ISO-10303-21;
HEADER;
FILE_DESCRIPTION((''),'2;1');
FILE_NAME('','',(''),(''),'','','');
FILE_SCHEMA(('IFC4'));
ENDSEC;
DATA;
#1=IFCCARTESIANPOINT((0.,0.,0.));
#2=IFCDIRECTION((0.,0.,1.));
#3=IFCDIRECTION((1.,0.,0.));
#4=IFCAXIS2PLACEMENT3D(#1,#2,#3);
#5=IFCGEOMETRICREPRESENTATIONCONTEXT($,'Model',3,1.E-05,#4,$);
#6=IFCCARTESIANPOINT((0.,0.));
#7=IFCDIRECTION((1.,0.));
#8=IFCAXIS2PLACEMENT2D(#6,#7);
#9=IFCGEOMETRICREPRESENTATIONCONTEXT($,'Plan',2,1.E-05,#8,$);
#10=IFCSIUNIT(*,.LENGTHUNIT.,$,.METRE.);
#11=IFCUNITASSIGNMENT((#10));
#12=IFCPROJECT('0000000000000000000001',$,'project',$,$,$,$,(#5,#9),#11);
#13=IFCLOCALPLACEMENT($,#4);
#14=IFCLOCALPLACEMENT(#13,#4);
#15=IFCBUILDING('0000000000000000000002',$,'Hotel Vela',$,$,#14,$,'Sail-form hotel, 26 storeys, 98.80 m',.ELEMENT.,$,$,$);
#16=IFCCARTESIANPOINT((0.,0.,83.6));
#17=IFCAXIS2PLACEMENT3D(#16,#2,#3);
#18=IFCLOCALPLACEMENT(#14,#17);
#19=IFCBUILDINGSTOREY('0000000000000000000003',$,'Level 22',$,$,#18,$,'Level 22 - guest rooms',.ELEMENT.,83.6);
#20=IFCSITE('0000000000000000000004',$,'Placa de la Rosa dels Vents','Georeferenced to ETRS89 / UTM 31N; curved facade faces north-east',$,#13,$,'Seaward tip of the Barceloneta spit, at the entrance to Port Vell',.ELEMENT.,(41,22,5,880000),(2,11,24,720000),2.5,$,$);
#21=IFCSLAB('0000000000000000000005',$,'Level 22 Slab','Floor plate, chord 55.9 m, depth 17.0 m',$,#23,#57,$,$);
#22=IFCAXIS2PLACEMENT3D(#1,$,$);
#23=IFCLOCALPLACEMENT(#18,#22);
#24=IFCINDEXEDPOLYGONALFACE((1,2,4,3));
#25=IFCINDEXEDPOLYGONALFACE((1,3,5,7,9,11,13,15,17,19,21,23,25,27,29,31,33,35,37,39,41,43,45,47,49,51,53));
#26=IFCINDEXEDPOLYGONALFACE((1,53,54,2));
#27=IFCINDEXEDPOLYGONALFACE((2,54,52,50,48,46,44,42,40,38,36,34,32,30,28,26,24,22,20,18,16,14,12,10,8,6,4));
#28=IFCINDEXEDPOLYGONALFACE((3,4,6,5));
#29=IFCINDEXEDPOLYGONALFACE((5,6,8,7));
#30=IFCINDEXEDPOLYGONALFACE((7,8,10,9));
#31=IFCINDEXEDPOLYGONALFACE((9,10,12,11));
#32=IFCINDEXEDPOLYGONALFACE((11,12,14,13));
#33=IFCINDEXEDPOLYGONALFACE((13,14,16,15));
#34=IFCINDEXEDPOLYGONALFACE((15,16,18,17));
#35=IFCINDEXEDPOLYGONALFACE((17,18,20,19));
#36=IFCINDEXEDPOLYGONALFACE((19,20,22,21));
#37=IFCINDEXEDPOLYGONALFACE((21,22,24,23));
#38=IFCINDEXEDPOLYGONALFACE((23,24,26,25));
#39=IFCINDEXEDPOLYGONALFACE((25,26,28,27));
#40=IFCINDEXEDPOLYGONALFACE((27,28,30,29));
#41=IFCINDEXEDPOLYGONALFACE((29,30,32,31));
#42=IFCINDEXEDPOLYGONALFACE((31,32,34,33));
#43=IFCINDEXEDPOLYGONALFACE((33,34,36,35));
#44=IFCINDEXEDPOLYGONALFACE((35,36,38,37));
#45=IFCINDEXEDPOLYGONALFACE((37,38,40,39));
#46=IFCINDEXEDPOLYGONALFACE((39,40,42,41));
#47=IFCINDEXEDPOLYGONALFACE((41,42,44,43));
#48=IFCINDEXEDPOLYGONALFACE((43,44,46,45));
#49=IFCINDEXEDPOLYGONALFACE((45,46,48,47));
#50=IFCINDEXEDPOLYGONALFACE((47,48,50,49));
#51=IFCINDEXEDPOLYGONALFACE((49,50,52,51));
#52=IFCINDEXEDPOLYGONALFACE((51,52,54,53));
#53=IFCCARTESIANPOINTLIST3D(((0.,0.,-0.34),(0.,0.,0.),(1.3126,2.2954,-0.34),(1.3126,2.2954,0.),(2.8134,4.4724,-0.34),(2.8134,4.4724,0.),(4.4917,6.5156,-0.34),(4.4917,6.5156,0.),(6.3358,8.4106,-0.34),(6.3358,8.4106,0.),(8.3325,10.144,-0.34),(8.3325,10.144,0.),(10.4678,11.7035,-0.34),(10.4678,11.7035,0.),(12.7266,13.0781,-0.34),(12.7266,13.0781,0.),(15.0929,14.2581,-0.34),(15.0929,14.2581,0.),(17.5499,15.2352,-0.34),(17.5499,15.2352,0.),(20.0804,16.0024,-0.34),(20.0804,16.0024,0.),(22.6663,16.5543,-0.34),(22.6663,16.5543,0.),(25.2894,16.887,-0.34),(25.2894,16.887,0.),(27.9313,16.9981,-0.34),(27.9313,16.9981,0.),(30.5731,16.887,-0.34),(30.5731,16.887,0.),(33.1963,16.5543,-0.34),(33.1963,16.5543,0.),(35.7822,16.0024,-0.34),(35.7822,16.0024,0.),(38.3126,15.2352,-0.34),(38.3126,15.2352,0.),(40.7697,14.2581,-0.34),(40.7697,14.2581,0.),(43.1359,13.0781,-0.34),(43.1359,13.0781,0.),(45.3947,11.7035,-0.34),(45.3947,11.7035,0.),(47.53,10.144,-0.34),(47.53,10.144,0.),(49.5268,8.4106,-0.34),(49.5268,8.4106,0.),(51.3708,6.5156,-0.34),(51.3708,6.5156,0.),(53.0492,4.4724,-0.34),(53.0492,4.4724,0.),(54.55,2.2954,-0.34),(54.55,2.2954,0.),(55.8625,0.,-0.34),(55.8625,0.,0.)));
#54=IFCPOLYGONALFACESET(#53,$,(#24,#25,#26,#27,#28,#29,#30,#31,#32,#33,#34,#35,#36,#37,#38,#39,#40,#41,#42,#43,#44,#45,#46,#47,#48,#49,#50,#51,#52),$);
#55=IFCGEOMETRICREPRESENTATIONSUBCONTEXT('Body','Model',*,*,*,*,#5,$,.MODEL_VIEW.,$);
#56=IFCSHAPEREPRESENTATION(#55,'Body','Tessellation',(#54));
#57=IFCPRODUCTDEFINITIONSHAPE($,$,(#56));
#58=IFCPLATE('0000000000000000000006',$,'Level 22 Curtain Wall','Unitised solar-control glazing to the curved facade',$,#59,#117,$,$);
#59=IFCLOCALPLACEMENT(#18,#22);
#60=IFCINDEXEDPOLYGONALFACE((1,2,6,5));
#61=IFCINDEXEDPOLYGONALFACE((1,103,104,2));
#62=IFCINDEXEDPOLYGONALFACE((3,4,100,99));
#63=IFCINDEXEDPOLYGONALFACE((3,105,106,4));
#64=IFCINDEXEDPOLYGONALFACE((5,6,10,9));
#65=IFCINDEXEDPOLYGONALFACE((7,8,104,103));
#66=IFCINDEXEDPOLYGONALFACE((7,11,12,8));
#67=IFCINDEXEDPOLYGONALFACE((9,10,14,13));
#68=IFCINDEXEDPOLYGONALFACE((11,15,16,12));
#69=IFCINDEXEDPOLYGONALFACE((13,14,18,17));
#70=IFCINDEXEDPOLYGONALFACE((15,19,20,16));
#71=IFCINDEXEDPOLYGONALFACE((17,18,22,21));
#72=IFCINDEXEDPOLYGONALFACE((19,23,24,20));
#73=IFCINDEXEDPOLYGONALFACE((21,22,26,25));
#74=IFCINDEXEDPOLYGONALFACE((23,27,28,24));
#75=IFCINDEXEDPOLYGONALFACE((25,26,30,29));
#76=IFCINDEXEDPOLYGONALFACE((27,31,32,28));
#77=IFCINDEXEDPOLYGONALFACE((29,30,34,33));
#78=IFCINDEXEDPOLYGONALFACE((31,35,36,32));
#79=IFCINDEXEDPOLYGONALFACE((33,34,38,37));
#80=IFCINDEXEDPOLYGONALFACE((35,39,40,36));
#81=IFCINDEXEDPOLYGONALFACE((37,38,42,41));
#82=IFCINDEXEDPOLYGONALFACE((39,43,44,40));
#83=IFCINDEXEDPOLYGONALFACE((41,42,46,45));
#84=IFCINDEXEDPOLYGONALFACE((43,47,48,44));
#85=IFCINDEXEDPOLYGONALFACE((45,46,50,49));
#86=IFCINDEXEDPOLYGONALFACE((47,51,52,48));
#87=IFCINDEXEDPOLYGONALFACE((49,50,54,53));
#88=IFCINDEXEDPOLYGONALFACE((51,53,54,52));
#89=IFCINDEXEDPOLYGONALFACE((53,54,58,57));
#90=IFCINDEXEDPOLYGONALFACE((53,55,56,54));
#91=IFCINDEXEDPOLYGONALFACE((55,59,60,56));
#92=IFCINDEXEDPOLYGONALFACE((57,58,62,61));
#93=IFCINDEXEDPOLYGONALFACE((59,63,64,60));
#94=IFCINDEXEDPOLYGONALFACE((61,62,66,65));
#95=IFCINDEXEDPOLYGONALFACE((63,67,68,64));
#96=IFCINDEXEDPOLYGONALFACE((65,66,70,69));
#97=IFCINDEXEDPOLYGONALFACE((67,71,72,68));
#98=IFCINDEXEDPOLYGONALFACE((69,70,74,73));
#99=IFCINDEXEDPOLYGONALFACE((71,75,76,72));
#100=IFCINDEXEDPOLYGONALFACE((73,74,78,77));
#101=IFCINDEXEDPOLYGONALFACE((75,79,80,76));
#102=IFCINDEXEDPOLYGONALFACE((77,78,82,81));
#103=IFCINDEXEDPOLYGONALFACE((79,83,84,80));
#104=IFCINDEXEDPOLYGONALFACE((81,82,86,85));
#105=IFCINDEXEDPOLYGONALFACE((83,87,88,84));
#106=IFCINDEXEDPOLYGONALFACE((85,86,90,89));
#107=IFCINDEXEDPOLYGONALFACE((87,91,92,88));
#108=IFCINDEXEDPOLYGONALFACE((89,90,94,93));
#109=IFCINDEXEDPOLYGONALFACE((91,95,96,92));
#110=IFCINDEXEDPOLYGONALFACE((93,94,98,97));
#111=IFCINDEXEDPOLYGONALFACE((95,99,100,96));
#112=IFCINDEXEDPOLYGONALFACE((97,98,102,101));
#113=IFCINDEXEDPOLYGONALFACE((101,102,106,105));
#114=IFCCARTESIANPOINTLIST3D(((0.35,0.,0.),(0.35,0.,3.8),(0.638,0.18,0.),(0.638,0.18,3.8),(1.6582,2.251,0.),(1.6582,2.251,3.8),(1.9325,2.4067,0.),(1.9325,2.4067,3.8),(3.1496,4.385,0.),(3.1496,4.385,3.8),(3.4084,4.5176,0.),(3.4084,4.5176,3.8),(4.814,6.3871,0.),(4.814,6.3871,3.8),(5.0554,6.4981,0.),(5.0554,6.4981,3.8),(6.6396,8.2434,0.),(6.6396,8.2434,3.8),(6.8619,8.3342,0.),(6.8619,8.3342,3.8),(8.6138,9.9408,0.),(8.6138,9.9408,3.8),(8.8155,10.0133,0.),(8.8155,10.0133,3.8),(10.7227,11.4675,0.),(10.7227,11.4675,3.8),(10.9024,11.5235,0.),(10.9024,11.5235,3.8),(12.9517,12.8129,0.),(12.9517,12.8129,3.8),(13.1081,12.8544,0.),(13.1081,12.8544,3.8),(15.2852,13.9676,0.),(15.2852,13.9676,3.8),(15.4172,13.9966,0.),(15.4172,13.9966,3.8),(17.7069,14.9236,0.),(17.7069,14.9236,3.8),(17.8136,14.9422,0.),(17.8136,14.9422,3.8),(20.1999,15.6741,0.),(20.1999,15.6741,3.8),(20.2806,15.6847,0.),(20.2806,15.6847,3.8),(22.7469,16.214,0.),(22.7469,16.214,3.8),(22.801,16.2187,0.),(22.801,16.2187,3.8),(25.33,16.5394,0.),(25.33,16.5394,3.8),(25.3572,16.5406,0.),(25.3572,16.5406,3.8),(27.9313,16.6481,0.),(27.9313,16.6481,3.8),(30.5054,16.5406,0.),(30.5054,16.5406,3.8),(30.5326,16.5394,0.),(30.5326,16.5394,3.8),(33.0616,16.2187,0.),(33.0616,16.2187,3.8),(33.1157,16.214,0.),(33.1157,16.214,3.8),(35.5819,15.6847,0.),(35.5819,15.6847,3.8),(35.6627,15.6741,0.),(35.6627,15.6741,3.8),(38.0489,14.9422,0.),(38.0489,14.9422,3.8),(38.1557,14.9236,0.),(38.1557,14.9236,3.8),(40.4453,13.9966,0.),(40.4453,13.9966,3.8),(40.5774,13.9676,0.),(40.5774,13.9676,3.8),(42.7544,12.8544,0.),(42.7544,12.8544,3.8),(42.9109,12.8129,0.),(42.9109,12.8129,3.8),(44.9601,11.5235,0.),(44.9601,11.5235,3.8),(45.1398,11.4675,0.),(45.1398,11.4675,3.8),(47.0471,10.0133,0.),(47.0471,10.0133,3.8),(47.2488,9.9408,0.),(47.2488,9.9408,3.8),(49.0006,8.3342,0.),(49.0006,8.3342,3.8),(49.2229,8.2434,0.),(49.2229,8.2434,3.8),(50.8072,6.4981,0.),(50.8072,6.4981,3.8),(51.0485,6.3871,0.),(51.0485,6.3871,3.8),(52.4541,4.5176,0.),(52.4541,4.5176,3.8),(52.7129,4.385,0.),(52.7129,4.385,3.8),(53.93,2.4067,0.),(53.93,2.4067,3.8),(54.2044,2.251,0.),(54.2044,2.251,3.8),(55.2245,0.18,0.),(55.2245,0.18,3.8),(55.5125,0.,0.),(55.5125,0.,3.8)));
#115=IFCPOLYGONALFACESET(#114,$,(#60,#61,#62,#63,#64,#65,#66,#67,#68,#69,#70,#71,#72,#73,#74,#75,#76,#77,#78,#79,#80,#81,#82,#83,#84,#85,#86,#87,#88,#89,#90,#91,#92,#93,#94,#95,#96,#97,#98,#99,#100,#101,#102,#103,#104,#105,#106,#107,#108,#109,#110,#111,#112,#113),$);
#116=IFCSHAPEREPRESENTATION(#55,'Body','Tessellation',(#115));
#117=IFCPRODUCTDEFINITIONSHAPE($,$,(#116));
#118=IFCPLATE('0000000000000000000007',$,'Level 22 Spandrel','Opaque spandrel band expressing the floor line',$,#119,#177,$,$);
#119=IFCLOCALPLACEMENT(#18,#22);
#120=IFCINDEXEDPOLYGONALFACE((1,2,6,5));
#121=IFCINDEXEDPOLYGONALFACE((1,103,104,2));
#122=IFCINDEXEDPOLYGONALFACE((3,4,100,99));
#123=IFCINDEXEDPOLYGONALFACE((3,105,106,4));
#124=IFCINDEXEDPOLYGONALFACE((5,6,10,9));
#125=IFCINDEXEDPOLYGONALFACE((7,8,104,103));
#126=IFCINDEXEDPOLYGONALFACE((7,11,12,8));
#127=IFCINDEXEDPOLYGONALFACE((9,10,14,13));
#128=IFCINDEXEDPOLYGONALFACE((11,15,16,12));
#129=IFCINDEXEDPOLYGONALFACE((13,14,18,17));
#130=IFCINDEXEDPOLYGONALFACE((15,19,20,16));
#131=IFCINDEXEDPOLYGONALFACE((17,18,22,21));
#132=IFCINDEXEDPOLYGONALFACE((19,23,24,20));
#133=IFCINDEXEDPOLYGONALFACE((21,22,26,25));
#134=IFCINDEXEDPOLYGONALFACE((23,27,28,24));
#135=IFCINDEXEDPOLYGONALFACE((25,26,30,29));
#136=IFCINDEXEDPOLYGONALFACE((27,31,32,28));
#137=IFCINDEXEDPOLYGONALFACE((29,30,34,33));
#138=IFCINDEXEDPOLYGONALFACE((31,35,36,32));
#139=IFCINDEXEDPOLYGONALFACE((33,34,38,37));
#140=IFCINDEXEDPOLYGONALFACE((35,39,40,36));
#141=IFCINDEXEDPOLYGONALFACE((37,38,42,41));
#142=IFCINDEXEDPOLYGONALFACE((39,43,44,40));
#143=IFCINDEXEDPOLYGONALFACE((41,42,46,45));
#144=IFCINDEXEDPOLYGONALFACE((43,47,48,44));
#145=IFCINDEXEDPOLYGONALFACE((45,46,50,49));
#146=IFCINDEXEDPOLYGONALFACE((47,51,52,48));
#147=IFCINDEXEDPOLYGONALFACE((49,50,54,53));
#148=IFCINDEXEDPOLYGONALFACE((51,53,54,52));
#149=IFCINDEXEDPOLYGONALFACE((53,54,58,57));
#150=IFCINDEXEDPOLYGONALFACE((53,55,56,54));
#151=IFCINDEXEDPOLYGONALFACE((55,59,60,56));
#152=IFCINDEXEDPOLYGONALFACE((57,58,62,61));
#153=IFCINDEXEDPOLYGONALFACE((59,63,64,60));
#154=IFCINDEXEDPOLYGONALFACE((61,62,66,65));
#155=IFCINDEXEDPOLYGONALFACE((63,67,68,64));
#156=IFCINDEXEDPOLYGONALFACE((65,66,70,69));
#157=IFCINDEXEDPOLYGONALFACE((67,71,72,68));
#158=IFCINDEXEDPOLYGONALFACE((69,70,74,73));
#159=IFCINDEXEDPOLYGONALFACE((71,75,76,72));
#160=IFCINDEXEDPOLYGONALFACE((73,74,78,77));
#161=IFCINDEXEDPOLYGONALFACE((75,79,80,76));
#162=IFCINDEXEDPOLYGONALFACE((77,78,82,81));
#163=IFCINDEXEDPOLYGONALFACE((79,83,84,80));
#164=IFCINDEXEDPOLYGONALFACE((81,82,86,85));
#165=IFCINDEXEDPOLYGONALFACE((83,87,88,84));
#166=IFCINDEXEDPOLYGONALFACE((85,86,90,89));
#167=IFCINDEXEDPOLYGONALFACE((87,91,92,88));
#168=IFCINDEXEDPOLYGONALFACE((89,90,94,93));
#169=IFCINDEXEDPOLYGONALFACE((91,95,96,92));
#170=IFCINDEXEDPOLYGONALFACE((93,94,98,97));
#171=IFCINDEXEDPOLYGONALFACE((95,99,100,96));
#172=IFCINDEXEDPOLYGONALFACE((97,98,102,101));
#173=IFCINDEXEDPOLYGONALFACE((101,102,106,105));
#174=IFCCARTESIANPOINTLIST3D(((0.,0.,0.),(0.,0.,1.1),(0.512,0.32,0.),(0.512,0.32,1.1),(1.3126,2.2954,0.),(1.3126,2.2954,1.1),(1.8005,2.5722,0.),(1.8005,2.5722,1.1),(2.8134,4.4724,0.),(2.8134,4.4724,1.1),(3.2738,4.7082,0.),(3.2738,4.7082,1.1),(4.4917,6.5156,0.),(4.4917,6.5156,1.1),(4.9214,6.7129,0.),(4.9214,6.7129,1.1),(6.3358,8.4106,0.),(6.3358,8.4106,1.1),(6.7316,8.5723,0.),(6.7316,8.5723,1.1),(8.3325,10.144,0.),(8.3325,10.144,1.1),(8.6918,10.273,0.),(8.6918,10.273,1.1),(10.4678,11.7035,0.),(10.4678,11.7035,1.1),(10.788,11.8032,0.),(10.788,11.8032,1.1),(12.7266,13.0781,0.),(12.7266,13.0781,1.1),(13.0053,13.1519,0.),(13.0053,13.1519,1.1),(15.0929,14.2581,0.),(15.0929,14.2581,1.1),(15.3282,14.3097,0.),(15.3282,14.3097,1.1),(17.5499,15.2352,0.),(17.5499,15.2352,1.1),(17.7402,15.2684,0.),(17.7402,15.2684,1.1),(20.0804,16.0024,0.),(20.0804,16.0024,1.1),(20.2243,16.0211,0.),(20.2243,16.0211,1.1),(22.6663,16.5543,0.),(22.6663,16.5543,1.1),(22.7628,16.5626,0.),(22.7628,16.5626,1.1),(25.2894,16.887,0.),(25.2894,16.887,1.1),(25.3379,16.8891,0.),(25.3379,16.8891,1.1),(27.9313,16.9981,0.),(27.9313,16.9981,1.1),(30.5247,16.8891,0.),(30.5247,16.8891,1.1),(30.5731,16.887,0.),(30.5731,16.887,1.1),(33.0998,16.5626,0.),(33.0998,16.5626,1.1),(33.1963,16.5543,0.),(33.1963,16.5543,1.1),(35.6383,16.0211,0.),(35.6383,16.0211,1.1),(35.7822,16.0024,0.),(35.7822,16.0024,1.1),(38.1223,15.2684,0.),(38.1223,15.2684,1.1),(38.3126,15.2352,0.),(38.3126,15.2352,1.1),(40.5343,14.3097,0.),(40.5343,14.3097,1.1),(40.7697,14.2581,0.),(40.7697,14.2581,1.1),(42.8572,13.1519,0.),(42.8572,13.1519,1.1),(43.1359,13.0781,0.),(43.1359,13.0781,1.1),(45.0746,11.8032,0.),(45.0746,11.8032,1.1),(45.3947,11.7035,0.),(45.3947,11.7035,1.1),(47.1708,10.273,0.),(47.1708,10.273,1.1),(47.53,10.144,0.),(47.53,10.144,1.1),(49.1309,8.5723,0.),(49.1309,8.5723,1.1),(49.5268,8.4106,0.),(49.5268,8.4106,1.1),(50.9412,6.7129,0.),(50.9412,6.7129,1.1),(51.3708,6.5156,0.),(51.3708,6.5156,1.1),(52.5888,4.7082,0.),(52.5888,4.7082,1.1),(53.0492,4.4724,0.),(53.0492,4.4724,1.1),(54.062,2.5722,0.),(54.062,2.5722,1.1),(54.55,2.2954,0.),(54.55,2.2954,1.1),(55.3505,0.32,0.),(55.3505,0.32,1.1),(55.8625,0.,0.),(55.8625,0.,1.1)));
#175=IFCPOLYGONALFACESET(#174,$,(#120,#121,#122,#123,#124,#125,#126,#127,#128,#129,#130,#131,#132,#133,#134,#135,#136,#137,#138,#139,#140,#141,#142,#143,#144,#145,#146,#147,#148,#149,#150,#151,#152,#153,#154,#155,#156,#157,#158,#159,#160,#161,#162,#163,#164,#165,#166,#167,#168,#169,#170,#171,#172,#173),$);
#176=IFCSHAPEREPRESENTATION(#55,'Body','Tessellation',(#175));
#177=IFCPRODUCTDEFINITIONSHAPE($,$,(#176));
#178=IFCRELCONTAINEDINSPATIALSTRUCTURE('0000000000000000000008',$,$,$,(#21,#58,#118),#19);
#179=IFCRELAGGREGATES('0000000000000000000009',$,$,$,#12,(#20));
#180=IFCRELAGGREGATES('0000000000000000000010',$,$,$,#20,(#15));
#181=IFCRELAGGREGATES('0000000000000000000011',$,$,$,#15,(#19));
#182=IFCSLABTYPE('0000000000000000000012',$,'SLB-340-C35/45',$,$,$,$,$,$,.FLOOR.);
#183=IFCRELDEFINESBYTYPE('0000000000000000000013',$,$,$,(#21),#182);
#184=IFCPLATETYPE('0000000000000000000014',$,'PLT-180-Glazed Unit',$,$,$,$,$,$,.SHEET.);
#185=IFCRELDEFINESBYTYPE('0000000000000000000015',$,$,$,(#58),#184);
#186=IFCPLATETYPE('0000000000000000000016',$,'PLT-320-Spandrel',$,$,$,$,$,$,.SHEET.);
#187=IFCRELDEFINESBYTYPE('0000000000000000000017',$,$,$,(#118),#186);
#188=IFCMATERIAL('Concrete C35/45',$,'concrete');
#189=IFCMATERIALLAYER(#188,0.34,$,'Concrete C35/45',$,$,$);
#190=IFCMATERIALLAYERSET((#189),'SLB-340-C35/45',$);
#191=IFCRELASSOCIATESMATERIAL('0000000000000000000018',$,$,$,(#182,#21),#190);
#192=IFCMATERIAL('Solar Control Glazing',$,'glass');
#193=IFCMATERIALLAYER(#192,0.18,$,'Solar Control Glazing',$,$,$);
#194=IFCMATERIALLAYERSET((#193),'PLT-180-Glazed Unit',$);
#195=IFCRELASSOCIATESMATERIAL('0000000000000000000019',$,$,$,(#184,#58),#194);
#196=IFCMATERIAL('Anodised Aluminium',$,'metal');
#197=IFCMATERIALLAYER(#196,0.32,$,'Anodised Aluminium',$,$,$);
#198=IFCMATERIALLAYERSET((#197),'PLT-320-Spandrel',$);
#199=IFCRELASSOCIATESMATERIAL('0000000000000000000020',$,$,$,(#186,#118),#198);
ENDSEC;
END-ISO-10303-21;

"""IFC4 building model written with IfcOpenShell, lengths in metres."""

from ifc_helpers import new_model, si_unit, frame, origin_with_axes, origin_2d_with_axis, place, context, subcontext, project, spatial, line, indexed_curve, outline, extrude, material, layer, layer_set, layer_usage, type_object, element, save


model = new_model("IFC4")

# Units and contexts
model_context = context("Model", 3, precision=1e-05, world=origin_with_axes())
plan_context = context("Plan", 2, precision=1e-05, world=origin_2d_with_axis())
body_context = subcontext(model_context, "Body", "Model", "MODEL_VIEW")
ifc_project = project(units=[si_unit("LENGTHUNIT", "METRE")], contexts=[model_context, plan_context])

# Site, building, storey
site_placement = place(None, origin_with_axes())
site = spatial("IfcSite", under=ifc_project, at=site_placement, Name="Placa de la Rosa dels Vents", Description="Georeferenced to ETRS89 / UTM 31N; curved facade faces north-east", LongName="Seaward tip of the Barceloneta spit, at the entrance to Port Vell", CompositionType="ELEMENT", RefLatitude=(41, 22, 5, 880000), RefLongitude=(2, 11, 24, 720000), RefElevation=2.5)
building_placement = place(site_placement, origin_with_axes())
building = spatial("IfcBuilding", under=site, at=building_placement, Name="Hotel Vela", LongName="Sail-form hotel, 26 storeys, 98.80 m", CompositionType="ELEMENT")
storey_placement = place(building_placement, frame((0.0, 0.0, 83.6), z_axis=(0.0, 0.0, 1.0), x_axis=(1.0, 0.0, 0.0)))
storey = spatial("IfcBuildingStorey", under=building, at=storey_placement, Name="Level 22", LongName="Level 22 - guest rooms", CompositionType="ELEMENT", Elevation=83.6)

# Slab
ifc_material_1 = material(Name="Concrete C35/45", Category="concrete")
ifc_layer_1 = layer(ifc_material_1, 0.34, Name="Concrete C35/45")
ifc_layer_set_1 = layer_set([ifc_layer_1], Name="SLB-340-C35/45")
ifc_layer_usage_1 = layer_usage(ifc_layer_set_1, "AXIS3", "POSITIVE", 0.0)
slab_type = type_object("IfcSlabType", Name="SLB-340-C35/45", PredefinedType="FLOOR", material=ifc_layer_set_1)
slab_placement = place(storey_placement, frame((0.0, 0.0, -0.34), z_axis=(0.0, 0.0, 1.0), x_axis=(1.0, 0.0, 0.0)))
element("IfcSlab", 1, at=slab_placement, inside=storey, type_object=slab_type, material=ifc_layer_usage_1, Name="Level 22 Slab", Description="Floor plate, chord 55.9 m, depth 17.0 m", context=body_context, shape_type="SweptSolid", body=[
    extrude(outline(indexed_curve([(0.0, 0.0), (55.8625, 0.0), (54.55, 2.2954), (53.0492, 4.4724), (51.3708, 6.5156), (49.5268, 8.4106), (47.53, 10.144), (45.3947, 11.7035), (43.1359, 13.0781), (40.7697, 14.2581), (38.3126, 15.2352), (35.7822, 16.0024), (33.1963, 16.5543), (30.5731, 16.887), (27.9313, 16.9981), (25.2894, 16.887), (22.6663, 16.5543), (20.0804, 16.0024), (17.5499, 15.2352), (15.0929, 14.2581), (12.7266, 13.0781), (10.4678, 11.7035), (8.3325, 10.144), (6.3358, 8.4106), (4.4917, 6.5156), (2.8134, 4.4724), (1.3126, 2.2954)], segments=[line(1, 2, 3, 4, 5, 6, 7, 8, 9, 10, 11, 12, 13, 14, 15, 16, 17, 18, 19, 20, 21, 22, 23, 24, 25, 26, 27, 1)])), origin_with_axes(), (0.0, 0.0, 1.0), 0.34),
])

# Plates
ifc_material_2 = material(Name="Solar Control Glazing", Category="glass")
ifc_layer_2 = layer(ifc_material_2, 0.18, Name="Solar Control Glazing")
ifc_layer_set_2 = layer_set([ifc_layer_2], Name="PLT-180-Glazed Unit")
ifc_layer_usage_2 = layer_usage(ifc_layer_set_2, "AXIS2", "POSITIVE", 0.0)
plate_type_1 = type_object("IfcPlateType", Name="PLT-180-Glazed Unit", PredefinedType="SHEET", material=ifc_layer_set_2)
plate_1_placement = place(storey_placement, frame((0.35, 0.0, 0.0), z_axis=(0.0, 0.0, 1.0), x_axis=(1.0, 0.0, 0.0)))
element("IfcPlate", 2, at=plate_1_placement, inside=storey, type_object=plate_type_1, material=ifc_layer_usage_2, Name="Level 22 Curtain Wall", Description="Unitised solar-control glazing to the curved facade", context=body_context, shape_type="SweptSolid", body=[
    extrude(outline(indexed_curve([(55.1625, 0.0), (53.8544, 2.251), (52.3629, 4.385), (50.6985, 6.3871), (48.8729, 8.2434), (46.8988, 9.9408), (44.7898, 11.4675), (42.5609, 12.8129), (40.2274, 13.9676), (37.8057, 14.9236), (35.3127, 15.6741), (32.7657, 16.214), (30.1826, 16.5394), (27.5813, 16.6481), (24.98, 16.5394), (22.3969, 16.214), (19.8499, 15.6741), (17.3569, 14.9236), (14.9352, 13.9676), (12.6017, 12.8129), (10.3727, 11.4675), (8.2638, 9.9408), (6.2896, 8.2434), (4.464, 6.3871), (2.7996, 4.385), (1.3082, 2.251), (0.0, 0.0), (54.8745, 0.18), (1.5825, 2.4067), (3.0584, 4.5176), (4.7054, 6.4981), (6.5119, 8.3342), (8.4655, 10.0133), (10.5524, 11.5235), (12.7581, 12.8544), (15.0672, 13.9966), (17.4636, 14.9422), (19.9306, 15.6847), (22.451, 16.2187), (25.0072, 16.5406), (27.5813, 16.6481), (30.1554, 16.5406), (32.7116, 16.2187), (35.2319, 15.6847), (37.6989, 14.9422), (40.0953, 13.9966), (42.4044, 12.8544), (44.6101, 11.5235), (46.6971, 10.0133), (48.6506, 8.3342), (50.4572, 6.4981), (52.1041, 4.5176), (53.58, 2.4067), (0.288, 0.18)], segments=[line(1, 2, 3, 4, 5, 6, 7, 8, 9, 10, 11, 12, 13, 14, 15, 16, 17, 18, 19, 20, 21, 22, 23, 24, 25, 26, 27, 28, 29, 30, 31, 32, 33, 34, 35, 36, 37, 38, 39, 40, 41, 42, 43, 44, 45, 46, 47, 48, 49, 50, 51, 52, 53, 54, 1)])), origin_with_axes(), (0.0, 0.0, 1.0), 3.8),
])
ifc_material_3 = material(Name="Anodised Aluminium", Category="metal")
ifc_layer_3 = layer(ifc_material_3, 0.32, Name="Anodised Aluminium")
ifc_layer_set_3 = layer_set([ifc_layer_3], Name="PLT-320-Spandrel")
ifc_layer_usage_3 = layer_usage(ifc_layer_set_3, "AXIS2", "POSITIVE", 0.0)
plate_type_2 = type_object("IfcPlateType", Name="PLT-320-Spandrel", PredefinedType="SHEET", material=ifc_layer_set_3)
plate_2_placement = place(storey_placement, origin_with_axes())
element("IfcPlate", 3, at=plate_2_placement, inside=storey, type_object=plate_type_2, material=ifc_layer_usage_3, Name="Level 22 Spandrel", Description="Opaque spandrel band expressing the floor line", context=body_context, shape_type="SweptSolid", body=[
    extrude(outline(indexed_curve([(55.8625, 0.0), (54.55, 2.2954), (53.0492, 4.4724), (51.3708, 6.5156), (49.5268, 8.4106), (47.53, 10.144), (45.3947, 11.7035), (43.1359, 13.0781), (40.7697, 14.2581), (38.3126, 15.2352), (35.7822, 16.0024), (33.1963, 16.5543), (30.5731, 16.887), (27.9313, 16.9981), (25.2894, 16.887), (22.6663, 16.5543), (20.0804, 16.0024), (17.5499, 15.2352), (15.0929, 14.2581), (12.7266, 13.0781), (10.4678, 11.7035), (8.3325, 10.144), (6.3358, 8.4106), (4.4917, 6.5156), (2.8134, 4.4724), (1.3126, 2.2954), (0.0, 0.0), (55.3505, 0.32), (1.8005, 2.5722), (3.2738, 4.7082), (4.9214, 6.7129), (6.7316, 8.5723), (8.6918, 10.273), (10.788, 11.8032), (13.0053, 13.1519), (15.3282, 14.3097), (17.7402, 15.2684), (20.2243, 16.0211), (22.7628, 16.5626), (25.3379, 16.8891), (27.9313, 16.9981), (30.5247, 16.8891), (33.0998, 16.5626), (35.6383, 16.0211), (38.1223, 15.2684), (40.5343, 14.3097), (42.8572, 13.1519), (45.0746, 11.8032), (47.1708, 10.273), (49.1309, 8.5723), (50.9412, 6.7129), (52.5888, 4.7082), (54.062, 2.5722), (0.512, 0.32)], segments=[line(1, 2, 3, 4, 5, 6, 7, 8, 9, 10, 11, 12, 13, 14, 15, 16, 17, 18, 19, 20, 21, 22, 23, 24, 25, 26, 27, 28, 29, 30, 31, 32, 33, 34, 35, 36, 37, 38, 39, 40, 41, 42, 43, 44, 45, 46, 47, 48, 49, 50, 51, 52, 53, 54, 1)])), origin_with_axes(), (0.0, 0.0, 1.0), 1.1),
])

save(model, "model.ifc")
